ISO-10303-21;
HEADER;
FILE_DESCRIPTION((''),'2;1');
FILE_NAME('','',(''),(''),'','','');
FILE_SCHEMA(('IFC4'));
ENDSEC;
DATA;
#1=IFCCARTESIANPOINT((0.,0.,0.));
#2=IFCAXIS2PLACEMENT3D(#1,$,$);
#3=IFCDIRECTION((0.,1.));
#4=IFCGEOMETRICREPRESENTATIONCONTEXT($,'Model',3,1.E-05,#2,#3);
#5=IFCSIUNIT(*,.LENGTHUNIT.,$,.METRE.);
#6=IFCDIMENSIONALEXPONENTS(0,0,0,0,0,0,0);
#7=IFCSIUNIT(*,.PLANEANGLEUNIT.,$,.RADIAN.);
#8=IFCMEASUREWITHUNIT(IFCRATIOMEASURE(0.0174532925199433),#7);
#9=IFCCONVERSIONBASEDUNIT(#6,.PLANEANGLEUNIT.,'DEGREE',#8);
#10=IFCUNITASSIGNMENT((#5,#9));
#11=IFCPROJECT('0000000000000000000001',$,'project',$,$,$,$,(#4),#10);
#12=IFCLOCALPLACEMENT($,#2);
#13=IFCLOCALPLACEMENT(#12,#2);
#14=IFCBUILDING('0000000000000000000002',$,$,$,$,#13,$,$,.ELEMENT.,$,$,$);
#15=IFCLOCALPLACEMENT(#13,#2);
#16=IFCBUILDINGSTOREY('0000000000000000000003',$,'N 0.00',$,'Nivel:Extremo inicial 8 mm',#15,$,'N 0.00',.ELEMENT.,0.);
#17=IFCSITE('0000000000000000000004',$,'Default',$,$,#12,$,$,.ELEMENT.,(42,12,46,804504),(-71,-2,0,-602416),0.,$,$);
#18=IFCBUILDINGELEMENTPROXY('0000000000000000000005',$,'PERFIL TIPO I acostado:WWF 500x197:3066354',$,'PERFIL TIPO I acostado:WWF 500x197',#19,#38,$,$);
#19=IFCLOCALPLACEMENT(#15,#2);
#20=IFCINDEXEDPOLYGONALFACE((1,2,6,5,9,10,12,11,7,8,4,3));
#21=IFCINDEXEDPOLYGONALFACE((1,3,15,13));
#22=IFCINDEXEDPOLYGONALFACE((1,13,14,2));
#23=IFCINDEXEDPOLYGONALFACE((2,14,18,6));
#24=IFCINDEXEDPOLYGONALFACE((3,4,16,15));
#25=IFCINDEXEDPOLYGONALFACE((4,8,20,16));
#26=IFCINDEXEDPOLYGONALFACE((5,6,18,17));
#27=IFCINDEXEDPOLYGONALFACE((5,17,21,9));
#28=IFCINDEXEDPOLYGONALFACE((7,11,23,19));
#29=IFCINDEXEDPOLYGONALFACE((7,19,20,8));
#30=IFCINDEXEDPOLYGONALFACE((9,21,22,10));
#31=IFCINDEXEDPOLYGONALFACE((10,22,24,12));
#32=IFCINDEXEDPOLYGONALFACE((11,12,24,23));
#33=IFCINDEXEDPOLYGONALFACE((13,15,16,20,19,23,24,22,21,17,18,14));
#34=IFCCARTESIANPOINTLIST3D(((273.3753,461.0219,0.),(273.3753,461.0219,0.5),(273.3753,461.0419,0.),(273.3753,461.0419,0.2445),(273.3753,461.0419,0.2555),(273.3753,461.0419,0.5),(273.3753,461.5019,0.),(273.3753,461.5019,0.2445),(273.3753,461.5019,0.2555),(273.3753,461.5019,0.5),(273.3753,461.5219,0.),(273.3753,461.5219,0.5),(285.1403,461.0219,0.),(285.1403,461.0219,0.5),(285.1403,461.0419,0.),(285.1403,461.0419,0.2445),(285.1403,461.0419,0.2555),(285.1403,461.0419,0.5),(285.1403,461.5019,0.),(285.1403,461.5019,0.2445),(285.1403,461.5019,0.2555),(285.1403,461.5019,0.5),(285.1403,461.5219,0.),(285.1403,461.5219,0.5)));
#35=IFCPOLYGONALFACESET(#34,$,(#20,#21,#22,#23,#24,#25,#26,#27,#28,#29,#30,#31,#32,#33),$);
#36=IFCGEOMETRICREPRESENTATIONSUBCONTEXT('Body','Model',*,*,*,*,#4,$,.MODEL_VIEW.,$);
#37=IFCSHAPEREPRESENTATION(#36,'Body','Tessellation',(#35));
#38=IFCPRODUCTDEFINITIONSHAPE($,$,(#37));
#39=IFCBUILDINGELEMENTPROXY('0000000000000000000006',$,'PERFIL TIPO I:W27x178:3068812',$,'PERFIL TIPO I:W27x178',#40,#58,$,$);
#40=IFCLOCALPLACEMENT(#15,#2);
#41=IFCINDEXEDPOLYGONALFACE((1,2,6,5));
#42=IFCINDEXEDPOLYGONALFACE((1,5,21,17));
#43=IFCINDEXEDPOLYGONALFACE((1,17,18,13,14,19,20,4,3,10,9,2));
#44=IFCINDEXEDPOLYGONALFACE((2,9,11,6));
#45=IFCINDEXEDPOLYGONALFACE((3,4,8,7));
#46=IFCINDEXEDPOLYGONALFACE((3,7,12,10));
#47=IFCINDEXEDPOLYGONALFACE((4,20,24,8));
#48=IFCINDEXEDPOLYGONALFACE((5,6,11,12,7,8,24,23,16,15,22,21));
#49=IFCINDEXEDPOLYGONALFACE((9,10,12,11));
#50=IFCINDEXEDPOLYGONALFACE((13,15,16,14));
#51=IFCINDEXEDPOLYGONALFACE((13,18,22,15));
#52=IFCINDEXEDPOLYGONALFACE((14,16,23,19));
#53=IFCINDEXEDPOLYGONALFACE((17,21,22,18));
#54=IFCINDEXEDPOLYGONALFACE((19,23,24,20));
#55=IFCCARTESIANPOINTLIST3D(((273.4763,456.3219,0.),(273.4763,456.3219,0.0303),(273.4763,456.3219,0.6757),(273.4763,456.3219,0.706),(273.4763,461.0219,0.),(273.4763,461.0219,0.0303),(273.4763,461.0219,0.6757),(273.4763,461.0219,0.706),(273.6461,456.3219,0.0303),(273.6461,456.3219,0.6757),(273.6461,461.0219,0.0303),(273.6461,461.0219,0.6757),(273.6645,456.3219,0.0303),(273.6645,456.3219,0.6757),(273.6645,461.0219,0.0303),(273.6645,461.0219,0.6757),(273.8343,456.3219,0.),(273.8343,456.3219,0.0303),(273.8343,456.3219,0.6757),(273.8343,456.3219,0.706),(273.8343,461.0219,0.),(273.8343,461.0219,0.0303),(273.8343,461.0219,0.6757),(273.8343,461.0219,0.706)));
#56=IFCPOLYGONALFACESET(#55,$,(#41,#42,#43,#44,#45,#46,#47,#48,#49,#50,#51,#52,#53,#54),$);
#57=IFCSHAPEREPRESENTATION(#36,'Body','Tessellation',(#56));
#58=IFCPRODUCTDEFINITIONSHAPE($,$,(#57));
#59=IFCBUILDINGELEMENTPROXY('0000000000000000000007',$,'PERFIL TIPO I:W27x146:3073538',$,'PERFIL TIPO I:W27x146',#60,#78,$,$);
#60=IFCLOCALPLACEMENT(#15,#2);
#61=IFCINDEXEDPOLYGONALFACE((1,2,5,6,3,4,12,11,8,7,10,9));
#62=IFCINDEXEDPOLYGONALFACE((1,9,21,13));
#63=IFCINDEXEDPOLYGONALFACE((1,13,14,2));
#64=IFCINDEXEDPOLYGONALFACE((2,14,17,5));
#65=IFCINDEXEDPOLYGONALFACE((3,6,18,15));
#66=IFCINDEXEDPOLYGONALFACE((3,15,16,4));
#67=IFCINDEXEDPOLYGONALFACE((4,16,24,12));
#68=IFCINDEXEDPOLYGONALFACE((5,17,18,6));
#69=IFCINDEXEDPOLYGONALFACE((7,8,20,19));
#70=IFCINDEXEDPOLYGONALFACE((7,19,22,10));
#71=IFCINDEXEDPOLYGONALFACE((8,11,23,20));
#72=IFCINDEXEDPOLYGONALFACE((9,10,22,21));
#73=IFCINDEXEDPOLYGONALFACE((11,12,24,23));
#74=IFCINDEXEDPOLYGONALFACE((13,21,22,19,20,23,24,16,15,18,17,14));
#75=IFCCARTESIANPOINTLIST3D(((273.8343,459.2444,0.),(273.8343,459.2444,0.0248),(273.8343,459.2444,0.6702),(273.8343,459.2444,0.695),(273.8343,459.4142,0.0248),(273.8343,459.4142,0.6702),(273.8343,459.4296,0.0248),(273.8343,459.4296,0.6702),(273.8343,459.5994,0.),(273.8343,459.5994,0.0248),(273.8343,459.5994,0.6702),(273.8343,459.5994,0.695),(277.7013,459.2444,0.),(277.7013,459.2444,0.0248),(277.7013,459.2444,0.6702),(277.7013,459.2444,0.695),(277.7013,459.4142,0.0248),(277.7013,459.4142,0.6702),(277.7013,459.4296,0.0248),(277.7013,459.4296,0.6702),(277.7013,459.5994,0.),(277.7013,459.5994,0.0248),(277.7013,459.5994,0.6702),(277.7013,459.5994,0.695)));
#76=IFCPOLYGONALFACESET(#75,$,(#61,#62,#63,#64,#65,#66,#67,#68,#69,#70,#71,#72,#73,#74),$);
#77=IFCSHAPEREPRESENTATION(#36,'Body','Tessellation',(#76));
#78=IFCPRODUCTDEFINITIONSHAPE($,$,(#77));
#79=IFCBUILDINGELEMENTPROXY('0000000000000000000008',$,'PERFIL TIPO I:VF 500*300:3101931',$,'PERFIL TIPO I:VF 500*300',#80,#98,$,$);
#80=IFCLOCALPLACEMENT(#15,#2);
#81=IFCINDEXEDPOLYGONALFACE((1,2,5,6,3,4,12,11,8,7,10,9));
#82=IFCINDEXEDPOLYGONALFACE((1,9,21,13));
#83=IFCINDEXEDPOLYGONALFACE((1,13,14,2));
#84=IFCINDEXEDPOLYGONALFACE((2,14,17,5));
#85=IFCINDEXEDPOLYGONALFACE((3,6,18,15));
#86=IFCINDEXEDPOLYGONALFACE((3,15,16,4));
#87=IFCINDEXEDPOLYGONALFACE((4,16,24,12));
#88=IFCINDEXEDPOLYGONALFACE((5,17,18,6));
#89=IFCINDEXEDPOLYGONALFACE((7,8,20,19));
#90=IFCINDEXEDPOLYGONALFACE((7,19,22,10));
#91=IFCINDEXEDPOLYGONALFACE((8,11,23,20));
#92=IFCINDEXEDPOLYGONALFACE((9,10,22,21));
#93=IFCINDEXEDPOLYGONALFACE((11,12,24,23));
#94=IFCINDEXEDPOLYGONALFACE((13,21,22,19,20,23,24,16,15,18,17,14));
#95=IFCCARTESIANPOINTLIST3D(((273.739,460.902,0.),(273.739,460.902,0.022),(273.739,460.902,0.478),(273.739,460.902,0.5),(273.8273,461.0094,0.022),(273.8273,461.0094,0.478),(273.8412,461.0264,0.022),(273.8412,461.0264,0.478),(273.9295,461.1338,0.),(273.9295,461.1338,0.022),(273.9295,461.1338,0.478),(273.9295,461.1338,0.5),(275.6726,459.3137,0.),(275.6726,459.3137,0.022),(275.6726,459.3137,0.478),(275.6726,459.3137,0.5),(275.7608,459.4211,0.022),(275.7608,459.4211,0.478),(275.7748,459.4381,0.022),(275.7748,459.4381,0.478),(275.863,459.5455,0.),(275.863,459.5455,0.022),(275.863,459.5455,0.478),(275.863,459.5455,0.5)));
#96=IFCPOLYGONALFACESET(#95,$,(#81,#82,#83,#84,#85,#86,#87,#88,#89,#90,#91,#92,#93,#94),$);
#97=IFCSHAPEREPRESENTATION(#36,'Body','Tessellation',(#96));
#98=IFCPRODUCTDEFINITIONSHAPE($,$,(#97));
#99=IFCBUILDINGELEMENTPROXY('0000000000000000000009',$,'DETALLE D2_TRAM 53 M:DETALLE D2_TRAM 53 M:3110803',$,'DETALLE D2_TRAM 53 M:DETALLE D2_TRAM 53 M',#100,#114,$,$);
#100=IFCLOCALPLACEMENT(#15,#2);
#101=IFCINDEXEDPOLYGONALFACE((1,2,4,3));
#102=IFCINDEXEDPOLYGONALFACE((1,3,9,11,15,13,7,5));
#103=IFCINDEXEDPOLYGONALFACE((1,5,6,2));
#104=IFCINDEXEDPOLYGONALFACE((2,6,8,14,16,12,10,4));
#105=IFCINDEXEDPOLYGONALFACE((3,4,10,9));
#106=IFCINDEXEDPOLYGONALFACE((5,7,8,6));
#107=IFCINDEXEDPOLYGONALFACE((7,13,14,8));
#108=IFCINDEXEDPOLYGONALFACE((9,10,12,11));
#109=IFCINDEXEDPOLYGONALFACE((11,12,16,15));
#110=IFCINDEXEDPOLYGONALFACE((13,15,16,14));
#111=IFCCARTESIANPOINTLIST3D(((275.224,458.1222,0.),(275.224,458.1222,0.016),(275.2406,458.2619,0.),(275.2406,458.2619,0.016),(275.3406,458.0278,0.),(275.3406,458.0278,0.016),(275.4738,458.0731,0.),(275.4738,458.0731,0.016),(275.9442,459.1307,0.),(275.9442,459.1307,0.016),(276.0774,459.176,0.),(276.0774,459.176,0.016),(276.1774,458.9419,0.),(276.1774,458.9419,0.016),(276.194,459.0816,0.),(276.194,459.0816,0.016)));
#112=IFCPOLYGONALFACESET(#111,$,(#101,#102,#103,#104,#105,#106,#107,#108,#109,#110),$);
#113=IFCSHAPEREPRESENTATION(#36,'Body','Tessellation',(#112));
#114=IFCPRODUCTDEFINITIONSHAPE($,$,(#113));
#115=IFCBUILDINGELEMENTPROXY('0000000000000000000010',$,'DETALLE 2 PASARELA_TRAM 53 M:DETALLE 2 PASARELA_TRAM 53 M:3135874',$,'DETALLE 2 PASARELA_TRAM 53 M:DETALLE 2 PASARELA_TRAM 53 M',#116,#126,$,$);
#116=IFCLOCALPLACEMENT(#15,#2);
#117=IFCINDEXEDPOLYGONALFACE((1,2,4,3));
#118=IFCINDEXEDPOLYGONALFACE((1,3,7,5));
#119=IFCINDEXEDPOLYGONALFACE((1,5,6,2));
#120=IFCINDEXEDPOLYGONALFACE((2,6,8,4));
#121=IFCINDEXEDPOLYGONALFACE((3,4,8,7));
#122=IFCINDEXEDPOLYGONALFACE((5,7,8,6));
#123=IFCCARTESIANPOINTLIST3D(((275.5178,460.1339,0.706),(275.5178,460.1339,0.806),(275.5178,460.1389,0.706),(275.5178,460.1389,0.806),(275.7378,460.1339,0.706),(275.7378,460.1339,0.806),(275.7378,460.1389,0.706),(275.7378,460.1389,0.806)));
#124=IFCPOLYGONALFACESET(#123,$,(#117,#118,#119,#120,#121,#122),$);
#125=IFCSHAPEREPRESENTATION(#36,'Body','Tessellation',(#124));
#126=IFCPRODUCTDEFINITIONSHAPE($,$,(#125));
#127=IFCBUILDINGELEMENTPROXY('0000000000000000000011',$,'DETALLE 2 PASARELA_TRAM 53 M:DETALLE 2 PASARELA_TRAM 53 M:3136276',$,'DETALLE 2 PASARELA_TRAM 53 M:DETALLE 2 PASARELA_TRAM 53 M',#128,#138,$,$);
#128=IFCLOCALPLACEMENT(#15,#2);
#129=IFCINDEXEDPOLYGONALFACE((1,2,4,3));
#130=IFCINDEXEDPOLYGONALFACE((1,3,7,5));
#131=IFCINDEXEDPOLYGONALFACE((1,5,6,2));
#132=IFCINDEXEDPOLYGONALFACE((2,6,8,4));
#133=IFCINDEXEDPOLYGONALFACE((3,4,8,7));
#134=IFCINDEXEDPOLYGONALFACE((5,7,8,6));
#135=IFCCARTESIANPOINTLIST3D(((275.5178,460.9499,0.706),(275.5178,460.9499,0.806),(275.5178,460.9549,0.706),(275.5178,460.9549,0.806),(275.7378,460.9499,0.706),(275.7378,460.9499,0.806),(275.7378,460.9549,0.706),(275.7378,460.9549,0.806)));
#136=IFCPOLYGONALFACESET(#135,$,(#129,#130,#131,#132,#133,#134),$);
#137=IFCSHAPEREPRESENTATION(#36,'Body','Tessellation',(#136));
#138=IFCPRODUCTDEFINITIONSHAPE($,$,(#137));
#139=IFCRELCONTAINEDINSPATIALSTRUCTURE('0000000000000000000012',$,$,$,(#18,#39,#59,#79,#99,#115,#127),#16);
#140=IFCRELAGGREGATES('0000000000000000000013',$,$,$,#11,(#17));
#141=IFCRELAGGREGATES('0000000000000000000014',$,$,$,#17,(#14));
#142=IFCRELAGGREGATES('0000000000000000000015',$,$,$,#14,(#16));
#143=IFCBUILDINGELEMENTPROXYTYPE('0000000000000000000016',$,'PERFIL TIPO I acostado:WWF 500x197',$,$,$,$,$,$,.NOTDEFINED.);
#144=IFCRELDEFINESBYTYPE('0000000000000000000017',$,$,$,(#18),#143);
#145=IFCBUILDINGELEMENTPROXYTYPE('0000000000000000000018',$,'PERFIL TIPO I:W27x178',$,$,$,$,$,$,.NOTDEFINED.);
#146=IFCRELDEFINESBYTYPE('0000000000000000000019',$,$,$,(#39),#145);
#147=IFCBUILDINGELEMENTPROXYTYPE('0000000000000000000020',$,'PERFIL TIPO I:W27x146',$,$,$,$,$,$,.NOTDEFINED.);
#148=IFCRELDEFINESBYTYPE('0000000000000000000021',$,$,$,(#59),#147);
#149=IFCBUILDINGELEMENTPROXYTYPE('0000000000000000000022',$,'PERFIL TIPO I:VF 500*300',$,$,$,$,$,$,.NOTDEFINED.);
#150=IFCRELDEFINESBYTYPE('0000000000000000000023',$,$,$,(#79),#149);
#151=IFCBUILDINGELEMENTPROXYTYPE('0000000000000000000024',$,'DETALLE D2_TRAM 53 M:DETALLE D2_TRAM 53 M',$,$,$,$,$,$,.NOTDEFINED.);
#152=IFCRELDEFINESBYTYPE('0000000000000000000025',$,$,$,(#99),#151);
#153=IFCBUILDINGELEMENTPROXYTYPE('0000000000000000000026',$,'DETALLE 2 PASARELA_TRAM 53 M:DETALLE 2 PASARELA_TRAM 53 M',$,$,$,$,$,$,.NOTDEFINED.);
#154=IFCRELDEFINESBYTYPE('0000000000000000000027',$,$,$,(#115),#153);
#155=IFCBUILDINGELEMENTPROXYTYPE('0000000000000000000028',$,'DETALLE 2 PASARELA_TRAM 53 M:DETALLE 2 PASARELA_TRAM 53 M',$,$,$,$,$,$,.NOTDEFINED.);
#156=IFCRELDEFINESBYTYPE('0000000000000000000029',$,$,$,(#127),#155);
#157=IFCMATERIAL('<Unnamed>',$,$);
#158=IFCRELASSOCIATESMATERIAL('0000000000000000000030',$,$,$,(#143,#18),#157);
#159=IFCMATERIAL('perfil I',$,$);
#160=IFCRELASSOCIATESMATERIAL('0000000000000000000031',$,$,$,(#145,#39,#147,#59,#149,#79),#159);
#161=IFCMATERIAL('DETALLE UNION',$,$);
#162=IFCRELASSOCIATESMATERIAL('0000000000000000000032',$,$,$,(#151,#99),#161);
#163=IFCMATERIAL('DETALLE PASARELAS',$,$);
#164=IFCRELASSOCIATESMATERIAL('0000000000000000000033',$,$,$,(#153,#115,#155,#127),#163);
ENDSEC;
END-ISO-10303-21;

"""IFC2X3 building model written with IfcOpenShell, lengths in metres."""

from ifc_helpers import new_model, entity, si_unit, converted_unit, direction, frame, frame_2d, origin, place, context, subcontext, project, spatial, polyline, rectangle, outline, extrude, source, transform, mapped, material, type_object, type_shapes, element, save


model = new_model("IFC2X3")

# Units and contexts
model_context = context("Model", 3, precision=1e-05, world=origin(), true_north=direction((0.0, 1.0)))
body_context = subcontext(model_context, "Body", "Model", "MODEL_VIEW")
ifc_project = project(units=[si_unit("LENGTHUNIT", "METRE"), converted_unit("PLANEANGLEUNIT", "DEGREE", entity("IfcRatioMeasure", 0.0174532925199433), si_unit("PLANEANGLEUNIT", "RADIAN"), dimensions=[0, 0, 0, 0, 0, 0, 0])], contexts=[model_context])

# Site, building, storey
site_placement = place(None, origin())
site = spatial("IfcSite", under=ifc_project, at=site_placement, Name="Default", CompositionType="ELEMENT", RefLatitude=(42, 12, 46, 804504), RefLongitude=(-71, -2, 0, -602416), RefElevation=0.0)
building_placement = place(site_placement, origin())
building = spatial("IfcBuilding", under=site, at=building_placement, CompositionType="ELEMENT")
storey_placement = place(building_placement, origin())
storey = spatial("IfcBuildingStorey", under=building, at=storey_placement, Name="N 0.00", ObjectType="Nivel:Extremo inicial 8 mm", LongName="N 0.00", CompositionType="ELEMENT", Elevation=0.0)

# Building element proxies
ifc_material_1 = material(Name="<Unnamed>")
building_element_proxy_type_1 = type_object("IfcBuildingElementProxyType", Name="PERFIL TIPO I acostado:WWF 500x197", PredefinedType="NOTDEFINED", material=ifc_material_1)
shared_shape_1 = source(origin(), body_context, "Body", "SweptSolid", [
    extrude(outline(polyline([(-0.25, -0.23), (-0.25, -0.25), (0.25, -0.25), (0.25, -0.23), (0.0055, -0.23), (0.0055, 0.23), (0.25, 0.23), (0.25, 0.25), (-0.25, 0.25), (-0.25, 0.23), (-0.0055, 0.23), (-0.0055, -0.23), (-0.25, -0.23)])), frame((0.0, 0.0, 0.25), z_axis=(-1.0, 0.0, 0.0), x_axis=(0.0, 0.0, -1.0)), (0.0, 0.0, -1.0), 11.765),
])
type_shapes(building_element_proxy_type_1, [shared_shape_1])
proxy_1_placement = place(storey_placement, frame((273.3753, 461.2719, 0.0)))
element("IfcBuildingElementProxy", 1, at=proxy_1_placement, inside=storey, type_object=building_element_proxy_type_1, material=ifc_material_1, Name="PERFIL TIPO I acostado:WWF 500x197:3066354", ObjectType="PERFIL TIPO I acostado:WWF 500x197", context=body_context, shape_type="MappedRepresentation", body=[
    mapped(shared_shape_1, transform((0.0, 0.0, 0.0), scale=1.0)),
])
ifc_material_2 = material(Name="perfil I")
building_element_proxy_type_2 = type_object("IfcBuildingElementProxyType", Name="PERFIL TIPO I:W27x178", PredefinedType="NOTDEFINED", material=ifc_material_2)
shared_shape_2 = source(origin(), body_context, "Body", "SweptSolid", [
    extrude(outline(polyline([(0.3227, -0.179), (0.353, -0.179), (0.353, 0.179), (0.3227, 0.179), (0.3227, 0.0092), (-0.3227, 0.0092), (-0.3227, 0.179), (-0.353, 0.179), (-0.353, -0.179), (-0.3227, -0.179), (-0.3227, -0.0092), (0.3227, -0.0092), (0.3227, -0.179)])), frame((0.0, 0.0, 0.353), z_axis=(1.0, 0.0, 0.0), x_axis=(0.0, 0.0, 1.0)), (0.0, 0.0, 1.0), 4.7),
])
type_shapes(building_element_proxy_type_2, [shared_shape_2])
proxy_2_placement = place(storey_placement, frame((273.6553, 461.0219, 0.0), z_axis=(0.0, 0.0, 1.0), x_axis=(0.0, -1.0, 0.0)))
element("IfcBuildingElementProxy", 2, at=proxy_2_placement, inside=storey, type_object=building_element_proxy_type_2, material=ifc_material_2, Name="PERFIL TIPO I:W27x178:3068812", ObjectType="PERFIL TIPO I:W27x178", context=body_context, shape_type="MappedRepresentation", body=[
    mapped(shared_shape_2, transform((0.0, 0.0, 0.0), scale=1.0)),
])
ifc_material_3 = material(Name="DETALLE UNION")
building_element_proxy_type_3 = type_object("IfcBuildingElementProxyType", Name="PERFIL TIPO I:W27x146", PredefinedType="NOTDEFINED", material=ifc_material_2)
shared_shape_3 = source(origin(), body_context, "Body", "SweptSolid", [
    extrude(outline(polyline([(0.3227, -0.1775), (0.3475, -0.1775), (0.3475, 0.1775), (0.3227, 0.1775), (0.3227, 0.0077), (-0.3227, 0.0077), (-0.3227, 0.1775), (-0.3475, 0.1775), (-0.3475, -0.1775), (-0.3227, -0.1775), (-0.3227, -0.0077), (0.3227, -0.0077), (0.3227, -0.1775)])), frame((0.0, 0.0, 0.3475), z_axis=(1.0, 0.0, 0.0), x_axis=(0.0, 0.0, 1.0)), (0.0, 0.0, 1.0), 3.867),
])
type_shapes(building_element_proxy_type_3, [shared_shape_3])
proxy_3_placement = place(storey_placement, frame((273.8343, 459.4219, 0.0)))
element("IfcBuildingElementProxy", 3, at=proxy_3_placement, inside=storey, type_object=building_element_proxy_type_3, material=ifc_material_2, Name="PERFIL TIPO I:W27x146:3073538", ObjectType="PERFIL TIPO I:W27x146", context=body_context, shape_type="MappedRepresentation", body=[
    mapped(shared_shape_3, transform((0.0, 0.0, 0.0), scale=1.0)),
])
building_element_proxy_type_4 = type_object("IfcBuildingElementProxyType", Name="PERFIL TIPO I:VF 500*300", PredefinedType="NOTDEFINED", material=ifc_material_2)
shared_shape_4 = source(origin(), body_context, "Body", "SweptSolid", [
    extrude(outline(polyline([(-0.15, -0.228), (-0.15, -0.25), (0.15, -0.25), (0.15, -0.228), (0.011, -0.228), (0.011, 0.228), (0.15, 0.228), (0.15, 0.25), (-0.15, 0.25), (-0.15, 0.228), (-0.011, 0.228), (-0.011, -0.228), (-0.15, -0.228)])), frame((0.0, 0.0, 0.25), z_axis=(-1.0, 0.0, 0.0), x_axis=(0.0, 1.0, 0.0)), (0.0, 0.0, -1.0), 2.5022),
])
type_shapes(building_element_proxy_type_4, [shared_shape_4])
proxy_4_placement = place(storey_placement, frame((275.7678, 459.4296, 0.0), z_axis=(0.0, 0.0, 1.0), x_axis=(-0.772718, 0.63475, 0.0)))
element("IfcBuildingElementProxy", 4, at=proxy_4_placement, inside=storey, type_object=building_element_proxy_type_4, material=ifc_material_2, Name="PERFIL TIPO I:VF 500*300:3101931", ObjectType="PERFIL TIPO I:VF 500*300", context=body_context, shape_type="MappedRepresentation", body=[
    mapped(shared_shape_4, transform((0.0, 0.0, 0.0), scale=1.0)),
])
building_element_proxy_type_5 = type_object("IfcBuildingElementProxyType", Name="DETALLE D2_TRAM 53 M:DETALLE D2_TRAM 53 M", PredefinedType="NOTDEFINED", material=ifc_material_3)
shared_shape_5 = source(origin(), body_context, "Body", "SweptSolid", [
    extrude(outline(polyline([(-0.075, -0.678), (0.075, -0.678), (0.15, -0.559), (0.15, 0.559), (0.075, 0.678), (-0.075, 0.678), (-0.15, 0.559), (-0.15, -0.559), (-0.075, -0.678)])), frame((0.0, 0.0, 0.0), z_axis=(0.0, 0.0, 1.0), x_axis=(-0.777146, 0.62932, 0.0)), (0.0, 0.0, 1.0), 0.016),
])
type_shapes(building_element_proxy_type_5, [shared_shape_5])
proxy_5_placement = place(storey_placement, frame((275.709, 458.6019, 0.0)))
element("IfcBuildingElementProxy", 5, at=proxy_5_placement, inside=storey, type_object=building_element_proxy_type_5, material=ifc_material_3, Name="DETALLE D2_TRAM 53 M:DETALLE D2_TRAM 53 M:3110803", ObjectType="DETALLE D2_TRAM 53 M:DETALLE D2_TRAM 53 M", context=body_context, shape_type="MappedRepresentation", body=[
    mapped(shared_shape_5, transform((0.0, 0.0, 0.0), scale=1.0)),
])
ifc_material_4 = material(Name="DETALLE PASARELAS")
building_element_proxy_type_6 = type_object("IfcBuildingElementProxyType", Name="DETALLE 2 PASARELA_TRAM 53 M:DETALLE 2 PASARELA_TRAM 53 M", PredefinedType="NOTDEFINED", material=ifc_material_4)
shared_shape_6 = source(origin(), body_context, "Body", "SweptSolid", [
    extrude(rectangle(XDim=0.22, YDim=0.005, at=frame_2d((0.0, 0.0), x_axis=(1.0, 0.0))), frame((0.11, 0.0475, 0.0), z_axis=(0.0, 0.0, 1.0), x_axis=(-1.0, 0.0, 0.0)), (0.0, 0.0, 1.0), 0.1),
])
type_shapes(building_element_proxy_type_6, [shared_shape_6])
proxy_6_placement = place(storey_placement, frame((275.5178, 460.0889, 0.706)))
element("IfcBuildingElementProxy", 6, at=proxy_6_placement, inside=storey, type_object=building_element_proxy_type_6, material=ifc_material_4, Name="DETALLE 2 PASARELA_TRAM 53 M:DETALLE 2 PASARELA_TRAM 53 M:3135874", ObjectType="DETALLE 2 PASARELA_TRAM 53 M:DETALLE 2 PASARELA_TRAM 53 M", context=body_context, shape_type="MappedRepresentation", body=[
    mapped(shared_shape_6, transform((0.0, 0.0, 0.0), scale=1.0)),
])
building_element_proxy_type_7 = type_object("IfcBuildingElementProxyType", Name="DETALLE 2 PASARELA_TRAM 53 M:DETALLE 2 PASARELA_TRAM 53 M", PredefinedType="NOTDEFINED", material=ifc_material_4)
shared_shape_7 = source(origin(), body_context, "Body", "SweptSolid", [
    extrude(rectangle(XDim=0.005, YDim=0.22, at=frame_2d((0.0, 0.0), x_axis=(1.0, 0.0))), frame((0.11, -0.0475, 0.0), z_axis=(0.0, 0.0, 1.0), x_axis=(0.0, 1.0, 0.0)), (0.0, 0.0, 1.0), 0.1),
])
type_shapes(building_element_proxy_type_7, [shared_shape_7])
proxy_7_placement = place(storey_placement, frame((275.5178, 460.9999, 0.706)))
element("IfcBuildingElementProxy", 7, at=proxy_7_placement, inside=storey, type_object=building_element_proxy_type_7, material=ifc_material_4, Name="DETALLE 2 PASARELA_TRAM 53 M:DETALLE 2 PASARELA_TRAM 53 M:3136276", ObjectType="DETALLE 2 PASARELA_TRAM 53 M:DETALLE 2 PASARELA_TRAM 53 M", context=body_context, shape_type="MappedRepresentation", body=[
    mapped(shared_shape_7, transform((0.0, 0.0, 0.0), scale=1.0)),
])

save(model, "model.ifc")
